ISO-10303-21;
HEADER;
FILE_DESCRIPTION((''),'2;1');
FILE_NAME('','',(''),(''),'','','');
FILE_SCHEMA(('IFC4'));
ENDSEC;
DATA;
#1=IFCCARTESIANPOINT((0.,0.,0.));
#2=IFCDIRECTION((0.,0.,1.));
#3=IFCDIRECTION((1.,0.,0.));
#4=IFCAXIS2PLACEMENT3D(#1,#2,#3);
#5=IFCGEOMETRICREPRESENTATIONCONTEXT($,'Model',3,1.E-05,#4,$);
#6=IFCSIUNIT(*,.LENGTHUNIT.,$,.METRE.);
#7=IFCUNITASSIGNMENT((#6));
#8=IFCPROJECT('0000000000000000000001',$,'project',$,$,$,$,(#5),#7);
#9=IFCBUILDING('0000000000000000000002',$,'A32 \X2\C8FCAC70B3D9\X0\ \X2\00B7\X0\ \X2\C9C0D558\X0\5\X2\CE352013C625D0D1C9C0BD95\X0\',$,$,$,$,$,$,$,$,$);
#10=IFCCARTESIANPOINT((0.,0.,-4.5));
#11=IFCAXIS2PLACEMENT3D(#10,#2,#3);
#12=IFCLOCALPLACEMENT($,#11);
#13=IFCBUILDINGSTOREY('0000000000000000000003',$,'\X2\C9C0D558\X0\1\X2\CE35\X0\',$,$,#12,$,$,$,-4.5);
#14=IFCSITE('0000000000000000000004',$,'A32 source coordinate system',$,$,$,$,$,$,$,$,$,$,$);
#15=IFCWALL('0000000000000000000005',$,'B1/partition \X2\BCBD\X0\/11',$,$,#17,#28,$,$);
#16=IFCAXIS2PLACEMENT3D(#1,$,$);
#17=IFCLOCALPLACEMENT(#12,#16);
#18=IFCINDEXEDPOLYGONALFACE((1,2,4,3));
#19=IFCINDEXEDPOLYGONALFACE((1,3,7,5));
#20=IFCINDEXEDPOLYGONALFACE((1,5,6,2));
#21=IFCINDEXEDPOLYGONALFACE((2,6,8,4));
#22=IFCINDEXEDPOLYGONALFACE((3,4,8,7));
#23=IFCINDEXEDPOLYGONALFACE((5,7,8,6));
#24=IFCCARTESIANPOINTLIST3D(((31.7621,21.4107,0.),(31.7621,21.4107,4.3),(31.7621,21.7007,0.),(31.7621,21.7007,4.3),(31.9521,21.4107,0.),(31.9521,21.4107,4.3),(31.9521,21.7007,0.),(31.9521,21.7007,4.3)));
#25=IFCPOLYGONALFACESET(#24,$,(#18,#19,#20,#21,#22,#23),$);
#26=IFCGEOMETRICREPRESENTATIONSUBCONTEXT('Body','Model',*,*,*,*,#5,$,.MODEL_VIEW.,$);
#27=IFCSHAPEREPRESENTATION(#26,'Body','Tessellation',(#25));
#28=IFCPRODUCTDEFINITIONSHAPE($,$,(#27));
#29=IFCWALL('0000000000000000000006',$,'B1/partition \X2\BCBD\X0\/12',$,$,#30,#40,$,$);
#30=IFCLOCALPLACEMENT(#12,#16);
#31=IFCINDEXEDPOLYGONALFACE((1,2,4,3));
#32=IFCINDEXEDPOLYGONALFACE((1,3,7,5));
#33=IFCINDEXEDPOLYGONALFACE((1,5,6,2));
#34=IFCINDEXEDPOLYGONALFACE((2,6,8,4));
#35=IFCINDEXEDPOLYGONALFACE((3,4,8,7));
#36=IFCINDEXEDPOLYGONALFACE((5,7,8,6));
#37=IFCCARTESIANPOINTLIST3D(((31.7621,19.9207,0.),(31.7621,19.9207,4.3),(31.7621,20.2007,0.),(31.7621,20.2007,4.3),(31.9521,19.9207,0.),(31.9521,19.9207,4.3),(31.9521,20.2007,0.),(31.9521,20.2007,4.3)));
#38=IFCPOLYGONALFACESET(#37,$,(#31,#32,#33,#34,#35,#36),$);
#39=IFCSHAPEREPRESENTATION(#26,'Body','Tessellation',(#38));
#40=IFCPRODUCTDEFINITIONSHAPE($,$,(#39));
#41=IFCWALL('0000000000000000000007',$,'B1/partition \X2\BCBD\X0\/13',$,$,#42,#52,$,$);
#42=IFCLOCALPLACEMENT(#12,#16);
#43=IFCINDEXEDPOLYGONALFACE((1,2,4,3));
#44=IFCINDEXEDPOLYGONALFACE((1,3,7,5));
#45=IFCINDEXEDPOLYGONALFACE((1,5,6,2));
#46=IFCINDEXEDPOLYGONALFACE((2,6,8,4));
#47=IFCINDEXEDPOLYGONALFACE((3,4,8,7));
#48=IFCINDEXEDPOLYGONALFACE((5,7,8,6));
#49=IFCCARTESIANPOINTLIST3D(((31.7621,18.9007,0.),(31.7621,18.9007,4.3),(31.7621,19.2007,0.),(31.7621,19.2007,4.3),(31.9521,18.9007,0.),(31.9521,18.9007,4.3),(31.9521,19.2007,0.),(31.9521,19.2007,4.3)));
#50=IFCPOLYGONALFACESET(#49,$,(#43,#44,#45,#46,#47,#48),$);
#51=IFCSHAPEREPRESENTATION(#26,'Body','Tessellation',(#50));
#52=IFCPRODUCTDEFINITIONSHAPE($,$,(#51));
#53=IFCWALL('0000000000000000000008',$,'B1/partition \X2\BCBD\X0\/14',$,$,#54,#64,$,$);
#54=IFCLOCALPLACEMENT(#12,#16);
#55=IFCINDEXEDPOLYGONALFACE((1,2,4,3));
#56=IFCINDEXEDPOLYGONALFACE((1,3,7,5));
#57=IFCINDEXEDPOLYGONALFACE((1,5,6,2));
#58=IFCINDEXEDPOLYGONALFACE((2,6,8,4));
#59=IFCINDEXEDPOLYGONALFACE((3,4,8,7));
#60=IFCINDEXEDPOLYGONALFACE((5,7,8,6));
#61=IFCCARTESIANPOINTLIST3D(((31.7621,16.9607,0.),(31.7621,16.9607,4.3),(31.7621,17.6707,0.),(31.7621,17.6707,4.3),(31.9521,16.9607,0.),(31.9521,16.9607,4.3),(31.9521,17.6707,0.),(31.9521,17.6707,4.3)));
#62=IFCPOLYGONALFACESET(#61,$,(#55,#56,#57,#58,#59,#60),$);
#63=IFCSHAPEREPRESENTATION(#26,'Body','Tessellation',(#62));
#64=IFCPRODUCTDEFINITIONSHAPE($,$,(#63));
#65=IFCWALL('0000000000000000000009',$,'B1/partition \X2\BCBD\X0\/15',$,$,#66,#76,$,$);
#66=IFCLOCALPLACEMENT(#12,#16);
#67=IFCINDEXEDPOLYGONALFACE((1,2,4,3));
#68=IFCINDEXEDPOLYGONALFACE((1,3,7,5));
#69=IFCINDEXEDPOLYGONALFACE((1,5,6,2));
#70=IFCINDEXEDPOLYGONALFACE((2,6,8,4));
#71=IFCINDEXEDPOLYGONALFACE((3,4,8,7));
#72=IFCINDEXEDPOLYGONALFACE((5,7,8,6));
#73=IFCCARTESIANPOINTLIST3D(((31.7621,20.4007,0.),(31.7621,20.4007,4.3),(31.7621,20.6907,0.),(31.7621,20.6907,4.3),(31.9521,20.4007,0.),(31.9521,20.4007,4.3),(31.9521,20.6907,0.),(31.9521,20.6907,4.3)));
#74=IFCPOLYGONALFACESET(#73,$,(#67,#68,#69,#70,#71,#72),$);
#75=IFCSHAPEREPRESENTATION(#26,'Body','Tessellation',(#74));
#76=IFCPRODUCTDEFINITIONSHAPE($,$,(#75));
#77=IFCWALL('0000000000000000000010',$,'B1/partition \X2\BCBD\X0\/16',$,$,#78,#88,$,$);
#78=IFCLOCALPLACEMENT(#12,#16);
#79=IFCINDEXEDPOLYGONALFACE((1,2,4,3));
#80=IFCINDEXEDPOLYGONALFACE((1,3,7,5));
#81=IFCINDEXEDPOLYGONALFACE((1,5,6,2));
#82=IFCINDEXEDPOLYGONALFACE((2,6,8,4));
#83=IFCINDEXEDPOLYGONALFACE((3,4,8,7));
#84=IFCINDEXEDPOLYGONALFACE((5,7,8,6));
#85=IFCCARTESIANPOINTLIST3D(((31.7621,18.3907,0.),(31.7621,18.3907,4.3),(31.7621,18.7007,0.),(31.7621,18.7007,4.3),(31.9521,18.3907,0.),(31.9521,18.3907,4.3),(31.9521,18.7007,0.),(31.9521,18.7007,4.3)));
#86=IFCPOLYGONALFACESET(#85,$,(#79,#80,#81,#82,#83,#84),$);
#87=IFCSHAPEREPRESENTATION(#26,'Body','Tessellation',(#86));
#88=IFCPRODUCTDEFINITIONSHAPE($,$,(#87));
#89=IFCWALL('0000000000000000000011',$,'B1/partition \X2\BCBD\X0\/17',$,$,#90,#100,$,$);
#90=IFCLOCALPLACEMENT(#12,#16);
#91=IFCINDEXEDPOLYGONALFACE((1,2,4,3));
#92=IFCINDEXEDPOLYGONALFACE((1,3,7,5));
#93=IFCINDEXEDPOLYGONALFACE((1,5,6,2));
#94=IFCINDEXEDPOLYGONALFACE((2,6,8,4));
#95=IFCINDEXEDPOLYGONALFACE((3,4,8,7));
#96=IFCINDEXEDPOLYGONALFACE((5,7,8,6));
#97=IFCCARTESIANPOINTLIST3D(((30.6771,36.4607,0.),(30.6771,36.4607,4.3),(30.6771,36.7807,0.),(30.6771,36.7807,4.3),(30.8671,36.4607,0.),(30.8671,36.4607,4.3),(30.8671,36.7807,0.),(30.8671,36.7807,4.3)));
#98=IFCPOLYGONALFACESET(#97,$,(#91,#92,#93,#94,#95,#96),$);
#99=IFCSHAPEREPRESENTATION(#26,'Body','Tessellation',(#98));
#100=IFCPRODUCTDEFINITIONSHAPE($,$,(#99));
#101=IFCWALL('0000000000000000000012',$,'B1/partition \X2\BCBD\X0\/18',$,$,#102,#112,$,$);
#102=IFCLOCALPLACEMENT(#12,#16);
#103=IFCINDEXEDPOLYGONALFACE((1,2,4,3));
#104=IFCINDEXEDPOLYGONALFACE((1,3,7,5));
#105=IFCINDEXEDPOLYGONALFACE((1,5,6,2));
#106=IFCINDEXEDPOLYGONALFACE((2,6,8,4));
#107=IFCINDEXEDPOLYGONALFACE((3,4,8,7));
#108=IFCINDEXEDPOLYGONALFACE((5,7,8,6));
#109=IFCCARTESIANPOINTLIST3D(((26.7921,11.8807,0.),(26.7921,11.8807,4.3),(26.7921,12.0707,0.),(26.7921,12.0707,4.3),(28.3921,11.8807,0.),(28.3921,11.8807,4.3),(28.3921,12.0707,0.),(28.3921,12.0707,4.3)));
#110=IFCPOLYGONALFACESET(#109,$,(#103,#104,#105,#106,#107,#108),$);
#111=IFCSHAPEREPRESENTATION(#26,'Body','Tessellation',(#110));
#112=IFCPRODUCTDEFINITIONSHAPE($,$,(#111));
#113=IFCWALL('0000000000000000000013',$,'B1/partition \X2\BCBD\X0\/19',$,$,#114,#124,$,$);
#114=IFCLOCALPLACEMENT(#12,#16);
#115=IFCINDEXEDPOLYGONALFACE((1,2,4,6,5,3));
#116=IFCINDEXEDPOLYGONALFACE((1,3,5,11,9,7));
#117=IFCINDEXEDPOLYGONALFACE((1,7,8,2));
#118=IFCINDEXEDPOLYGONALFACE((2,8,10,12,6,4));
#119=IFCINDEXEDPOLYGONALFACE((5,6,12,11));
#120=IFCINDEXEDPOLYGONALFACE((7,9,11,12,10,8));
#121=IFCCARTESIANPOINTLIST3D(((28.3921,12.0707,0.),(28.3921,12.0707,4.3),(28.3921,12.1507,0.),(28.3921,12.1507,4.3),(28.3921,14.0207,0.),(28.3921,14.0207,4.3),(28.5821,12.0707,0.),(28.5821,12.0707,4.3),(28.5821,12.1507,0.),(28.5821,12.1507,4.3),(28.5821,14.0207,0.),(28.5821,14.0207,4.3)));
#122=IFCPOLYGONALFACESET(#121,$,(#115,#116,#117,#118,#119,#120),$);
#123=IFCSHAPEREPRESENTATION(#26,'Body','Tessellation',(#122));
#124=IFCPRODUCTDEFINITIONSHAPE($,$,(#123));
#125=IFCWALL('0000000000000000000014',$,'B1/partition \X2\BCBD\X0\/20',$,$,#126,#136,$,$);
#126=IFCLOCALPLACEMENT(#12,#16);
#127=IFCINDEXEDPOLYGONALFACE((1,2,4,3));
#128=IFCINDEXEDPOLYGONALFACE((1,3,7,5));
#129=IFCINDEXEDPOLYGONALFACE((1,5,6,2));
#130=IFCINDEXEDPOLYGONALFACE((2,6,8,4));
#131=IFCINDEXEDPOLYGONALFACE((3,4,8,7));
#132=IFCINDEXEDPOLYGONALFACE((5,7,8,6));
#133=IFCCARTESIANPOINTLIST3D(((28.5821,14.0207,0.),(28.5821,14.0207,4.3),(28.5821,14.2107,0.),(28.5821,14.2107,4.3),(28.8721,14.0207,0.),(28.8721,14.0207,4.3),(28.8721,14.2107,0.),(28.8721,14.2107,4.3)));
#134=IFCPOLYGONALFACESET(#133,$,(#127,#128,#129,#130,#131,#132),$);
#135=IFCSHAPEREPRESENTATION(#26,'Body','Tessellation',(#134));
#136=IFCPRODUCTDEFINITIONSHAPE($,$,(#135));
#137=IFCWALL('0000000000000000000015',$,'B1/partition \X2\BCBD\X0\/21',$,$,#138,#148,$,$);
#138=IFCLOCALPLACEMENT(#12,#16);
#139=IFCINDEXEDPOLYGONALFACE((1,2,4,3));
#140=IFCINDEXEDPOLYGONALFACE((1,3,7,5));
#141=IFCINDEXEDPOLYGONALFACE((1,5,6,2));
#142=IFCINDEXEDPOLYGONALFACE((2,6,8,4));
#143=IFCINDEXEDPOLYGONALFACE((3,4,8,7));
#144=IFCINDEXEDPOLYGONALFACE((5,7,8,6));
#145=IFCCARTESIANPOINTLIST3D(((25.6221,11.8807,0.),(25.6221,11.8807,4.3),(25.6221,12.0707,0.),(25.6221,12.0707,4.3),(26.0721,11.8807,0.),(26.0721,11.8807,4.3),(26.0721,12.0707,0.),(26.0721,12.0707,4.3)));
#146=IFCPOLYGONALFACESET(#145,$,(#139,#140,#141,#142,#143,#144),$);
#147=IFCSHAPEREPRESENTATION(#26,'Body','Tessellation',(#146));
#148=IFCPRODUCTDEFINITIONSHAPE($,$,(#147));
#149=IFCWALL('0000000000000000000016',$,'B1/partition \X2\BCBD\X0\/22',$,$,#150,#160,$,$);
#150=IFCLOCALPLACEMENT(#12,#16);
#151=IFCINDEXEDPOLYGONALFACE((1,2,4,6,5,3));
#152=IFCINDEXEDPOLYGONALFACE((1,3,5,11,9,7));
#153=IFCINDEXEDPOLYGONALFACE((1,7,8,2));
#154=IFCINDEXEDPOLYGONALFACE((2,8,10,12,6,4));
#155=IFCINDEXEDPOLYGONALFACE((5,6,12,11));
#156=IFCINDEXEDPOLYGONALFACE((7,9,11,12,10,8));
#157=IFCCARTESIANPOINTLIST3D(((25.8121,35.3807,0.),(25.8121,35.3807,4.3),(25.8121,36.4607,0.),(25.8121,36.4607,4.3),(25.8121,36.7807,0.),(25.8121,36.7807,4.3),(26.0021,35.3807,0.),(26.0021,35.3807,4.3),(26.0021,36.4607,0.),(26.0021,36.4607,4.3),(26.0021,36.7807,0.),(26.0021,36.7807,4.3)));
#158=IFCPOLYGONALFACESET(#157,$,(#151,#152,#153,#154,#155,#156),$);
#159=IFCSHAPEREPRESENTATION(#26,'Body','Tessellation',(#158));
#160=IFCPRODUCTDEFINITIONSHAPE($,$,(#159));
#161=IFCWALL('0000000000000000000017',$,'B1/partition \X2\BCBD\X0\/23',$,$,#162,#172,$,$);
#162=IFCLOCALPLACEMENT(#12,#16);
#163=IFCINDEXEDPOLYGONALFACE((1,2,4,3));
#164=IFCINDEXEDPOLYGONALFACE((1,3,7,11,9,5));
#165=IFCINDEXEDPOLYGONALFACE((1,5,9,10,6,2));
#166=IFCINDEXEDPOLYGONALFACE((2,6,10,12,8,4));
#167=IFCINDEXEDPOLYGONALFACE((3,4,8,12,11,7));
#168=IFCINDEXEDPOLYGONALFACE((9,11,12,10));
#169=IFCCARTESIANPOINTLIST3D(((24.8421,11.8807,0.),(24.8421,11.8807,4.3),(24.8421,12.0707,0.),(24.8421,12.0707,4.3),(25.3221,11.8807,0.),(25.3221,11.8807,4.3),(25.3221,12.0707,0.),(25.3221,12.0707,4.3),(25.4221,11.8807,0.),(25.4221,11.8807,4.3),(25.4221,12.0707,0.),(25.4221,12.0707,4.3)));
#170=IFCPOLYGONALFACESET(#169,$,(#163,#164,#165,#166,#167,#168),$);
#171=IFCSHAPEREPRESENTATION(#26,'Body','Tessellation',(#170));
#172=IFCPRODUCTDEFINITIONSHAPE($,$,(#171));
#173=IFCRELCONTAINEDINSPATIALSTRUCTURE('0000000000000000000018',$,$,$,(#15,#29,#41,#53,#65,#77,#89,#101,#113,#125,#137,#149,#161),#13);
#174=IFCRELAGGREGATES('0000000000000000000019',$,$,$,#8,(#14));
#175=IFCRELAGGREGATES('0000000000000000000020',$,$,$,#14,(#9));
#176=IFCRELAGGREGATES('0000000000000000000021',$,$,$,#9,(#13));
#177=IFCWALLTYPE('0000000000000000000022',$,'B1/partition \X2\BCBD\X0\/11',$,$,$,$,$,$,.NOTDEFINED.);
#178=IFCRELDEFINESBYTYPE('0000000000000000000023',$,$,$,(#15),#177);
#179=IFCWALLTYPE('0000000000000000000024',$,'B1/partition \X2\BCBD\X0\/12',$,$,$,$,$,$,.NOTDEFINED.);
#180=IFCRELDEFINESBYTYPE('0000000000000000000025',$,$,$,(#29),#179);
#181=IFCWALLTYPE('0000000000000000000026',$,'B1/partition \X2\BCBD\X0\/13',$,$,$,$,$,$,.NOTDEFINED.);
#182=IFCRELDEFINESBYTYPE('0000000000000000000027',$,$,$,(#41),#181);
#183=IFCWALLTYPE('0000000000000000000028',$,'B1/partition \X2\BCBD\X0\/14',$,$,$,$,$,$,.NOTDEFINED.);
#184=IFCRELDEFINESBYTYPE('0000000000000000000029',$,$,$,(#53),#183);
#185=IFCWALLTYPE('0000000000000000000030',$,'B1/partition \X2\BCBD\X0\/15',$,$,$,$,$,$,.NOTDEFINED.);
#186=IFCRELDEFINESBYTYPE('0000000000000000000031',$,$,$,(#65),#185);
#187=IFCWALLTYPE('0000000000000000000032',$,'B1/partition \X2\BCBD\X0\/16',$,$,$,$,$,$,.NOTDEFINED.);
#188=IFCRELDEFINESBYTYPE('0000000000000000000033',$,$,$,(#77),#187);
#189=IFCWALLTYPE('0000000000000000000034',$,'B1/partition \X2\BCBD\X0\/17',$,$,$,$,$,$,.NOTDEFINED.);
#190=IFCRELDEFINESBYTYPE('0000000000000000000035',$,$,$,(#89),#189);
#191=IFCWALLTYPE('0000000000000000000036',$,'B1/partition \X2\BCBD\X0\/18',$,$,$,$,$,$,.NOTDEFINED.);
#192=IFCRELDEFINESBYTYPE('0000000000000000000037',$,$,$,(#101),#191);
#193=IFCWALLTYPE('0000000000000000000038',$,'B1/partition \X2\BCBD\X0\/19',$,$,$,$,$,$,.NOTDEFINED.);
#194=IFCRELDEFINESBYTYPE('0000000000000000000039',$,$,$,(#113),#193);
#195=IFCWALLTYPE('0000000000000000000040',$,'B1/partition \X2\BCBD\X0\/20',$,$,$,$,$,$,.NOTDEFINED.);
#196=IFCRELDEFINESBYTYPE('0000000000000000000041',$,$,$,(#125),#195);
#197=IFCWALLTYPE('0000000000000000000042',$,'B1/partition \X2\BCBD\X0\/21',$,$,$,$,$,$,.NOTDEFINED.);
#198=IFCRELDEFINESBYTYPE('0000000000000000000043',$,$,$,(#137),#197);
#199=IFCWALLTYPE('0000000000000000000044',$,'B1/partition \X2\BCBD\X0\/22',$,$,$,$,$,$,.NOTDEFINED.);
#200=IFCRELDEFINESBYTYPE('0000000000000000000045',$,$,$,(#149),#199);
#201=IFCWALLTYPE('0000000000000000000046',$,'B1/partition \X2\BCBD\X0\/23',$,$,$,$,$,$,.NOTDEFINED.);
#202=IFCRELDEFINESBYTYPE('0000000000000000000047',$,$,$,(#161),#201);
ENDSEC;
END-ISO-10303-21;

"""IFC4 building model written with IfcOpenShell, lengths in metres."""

from ifc_helpers import new_model, si_unit, frame, origin, origin_with_axes, place, context, subcontext, project, spatial, polyline, outline, extrude, source, transform, mapped, type_object, type_shapes, element, save


model = new_model("IFC4")

# Units and contexts
model_context = context("Model", 3, precision=1e-05, world=origin_with_axes())
body_context = subcontext(model_context, "Body", "Model", "MODEL_VIEW")
ifc_project = project(units=[si_unit("LENGTHUNIT", "METRE")], contexts=[model_context])

# Site, building, storey
site = spatial("IfcSite", under=ifc_project, Name="A32 source coordinate system")
building = spatial("IfcBuilding", under=site, Name="A32 주거동 · 지하5층–옥탑지붕")
storey_placement = place(None, frame((0.0, 0.0, -4.5), z_axis=(0.0, 0.0, 1.0), x_axis=(1.0, 0.0, 0.0)))
storey = spatial("IfcBuildingStorey", under=building, at=storey_placement, Name="지하1층", Elevation=-4.5)

# Walls
wall_type_1 = type_object("IfcWallType", Name="B1/partition 벽/11", PredefinedType="NOTDEFINED")
shared_shape_1 = source(origin(), body_context, "Body", "SweptSolid", [
    extrude(outline(polyline([(31.9521, 21.4107), (31.7621, 21.4107), (31.7621, 21.7007), (31.9521, 21.7007), (31.9521, 21.4107)])), origin(), (0.0, 0.0, 1.0), 4.3),
])
type_shapes(wall_type_1, [shared_shape_1])
wall_1_placement = place(storey_placement, origin_with_axes())
element("IfcWall", 1, at=wall_1_placement, inside=storey, type_object=wall_type_1, Name="B1/partition 벽/11", context=body_context, shape_type="MappedRepresentation", body=[
    mapped(shared_shape_1, transform((0.0, 0.0, 0.0), scale=1.0)),
])
wall_type_2 = type_object("IfcWallType", Name="B1/partition 벽/12", PredefinedType="NOTDEFINED")
shared_shape_2 = source(origin(), body_context, "Body", "SweptSolid", [
    extrude(outline(polyline([(31.9521, 19.9207), (31.7621, 19.9207), (31.7621, 20.2007), (31.9521, 20.2007), (31.9521, 19.9207)])), origin(), (0.0, 0.0, 1.0), 4.3),
])
type_shapes(wall_type_2, [shared_shape_2])
wall_2_placement = place(storey_placement, origin_with_axes())
element("IfcWall", 2, at=wall_2_placement, inside=storey, type_object=wall_type_2, Name="B1/partition 벽/12", context=body_context, shape_type="MappedRepresentation", body=[
    mapped(shared_shape_2, transform((0.0, 0.0, 0.0), scale=1.0)),
])
wall_type_3 = type_object("IfcWallType", Name="B1/partition 벽/13", PredefinedType="NOTDEFINED")
shared_shape_3 = source(origin(), body_context, "Body", "SweptSolid", [
    extrude(outline(polyline([(31.9521, 18.9007), (31.7621, 18.9007), (31.7621, 19.2007), (31.9521, 19.2007), (31.9521, 18.9007)])), origin(), (0.0, 0.0, 1.0), 4.3),
])
type_shapes(wall_type_3, [shared_shape_3])
wall_3_placement = place(storey_placement, origin_with_axes())
element("IfcWall", 3, at=wall_3_placement, inside=storey, type_object=wall_type_3, Name="B1/partition 벽/13", context=body_context, shape_type="MappedRepresentation", body=[
    mapped(shared_shape_3, transform((0.0, 0.0, 0.0), scale=1.0)),
])
wall_type_4 = type_object("IfcWallType", Name="B1/partition 벽/14", PredefinedType="NOTDEFINED")
shared_shape_4 = source(origin(), body_context, "Body", "SweptSolid", [
    extrude(outline(polyline([(31.9521, 16.9607), (31.7621, 16.9607), (31.7621, 17.6707), (31.9521, 17.6707), (31.9521, 16.9607)])), origin(), (0.0, 0.0, 1.0), 4.3),
])
type_shapes(wall_type_4, [shared_shape_4])
wall_4_placement = place(storey_placement, origin_with_axes())
element("IfcWall", 4, at=wall_4_placement, inside=storey, type_object=wall_type_4, Name="B1/partition 벽/14", context=body_context, shape_type="MappedRepresentation", body=[
    mapped(shared_shape_4, transform((0.0, 0.0, 0.0), scale=1.0)),
])
wall_type_5 = type_object("IfcWallType", Name="B1/partition 벽/15", PredefinedType="NOTDEFINED")
shared_shape_5 = source(origin(), body_context, "Body", "SweptSolid", [
    extrude(outline(polyline([(31.9521, 20.6907), (31.9521, 20.4007), (31.7621, 20.4007), (31.7621, 20.6907), (31.9521, 20.6907)])), origin(), (0.0, 0.0, 1.0), 4.3),
])
type_shapes(wall_type_5, [shared_shape_5])
wall_5_placement = place(storey_placement, origin_with_axes())
element("IfcWall", 5, at=wall_5_placement, inside=storey, type_object=wall_type_5, Name="B1/partition 벽/15", context=body_context, shape_type="MappedRepresentation", body=[
    mapped(shared_shape_5, transform((0.0, 0.0, 0.0), scale=1.0)),
])
wall_type_6 = type_object("IfcWallType", Name="B1/partition 벽/16", PredefinedType="NOTDEFINED")
shared_shape_6 = source(origin(), body_context, "Body", "SweptSolid", [
    extrude(outline(polyline([(31.9521, 18.7007), (31.9521, 18.3907), (31.7621, 18.3907), (31.7621, 18.7007), (31.9521, 18.7007)])), origin(), (0.0, 0.0, 1.0), 4.3),
])
type_shapes(wall_type_6, [shared_shape_6])
wall_6_placement = place(storey_placement, origin_with_axes())
element("IfcWall", 6, at=wall_6_placement, inside=storey, type_object=wall_type_6, Name="B1/partition 벽/16", context=body_context, shape_type="MappedRepresentation", body=[
    mapped(shared_shape_6, transform((0.0, 0.0, 0.0), scale=1.0)),
])
wall_type_7 = type_object("IfcWallType", Name="B1/partition 벽/17", PredefinedType="NOTDEFINED")
shared_shape_7 = source(origin(), body_context, "Body", "SweptSolid", [
    extrude(outline(polyline([(30.8671, 36.4607), (30.6771, 36.4607), (30.6771, 36.7807), (30.8671, 36.7807), (30.8671, 36.4607)])), origin(), (0.0, 0.0, 1.0), 4.3),
])
type_shapes(wall_type_7, [shared_shape_7])
wall_7_placement = place(storey_placement, origin_with_axes())
element("IfcWall", 7, at=wall_7_placement, inside=storey, type_object=wall_type_7, Name="B1/partition 벽/17", context=body_context, shape_type="MappedRepresentation", body=[
    mapped(shared_shape_7, transform((0.0, 0.0, 0.0), scale=1.0)),
])
wall_type_8 = type_object("IfcWallType", Name="B1/partition 벽/18", PredefinedType="NOTDEFINED")
shared_shape_8 = source(origin(), body_context, "Body", "SweptSolid", [
    extrude(outline(polyline([(28.3921, 12.0707), (28.3921, 11.8807), (26.7921, 11.8807), (26.7921, 12.0707), (28.3921, 12.0707)])), origin(), (0.0, 0.0, 1.0), 4.3),
])
type_shapes(wall_type_8, [shared_shape_8])
wall_8_placement = place(storey_placement, origin_with_axes())
element("IfcWall", 8, at=wall_8_placement, inside=storey, type_object=wall_type_8, Name="B1/partition 벽/18", context=body_context, shape_type="MappedRepresentation", body=[
    mapped(shared_shape_8, transform((0.0, 0.0, 0.0), scale=1.0)),
])
wall_type_9 = type_object("IfcWallType", Name="B1/partition 벽/19", PredefinedType="NOTDEFINED")
shared_shape_9 = source(origin(), body_context, "Body", "SweptSolid", [
    extrude(outline(polyline([(28.3921, 12.1507), (28.3921, 14.0207), (28.5821, 14.0207), (28.5821, 12.1507), (28.5821, 12.0707), (28.3921, 12.0707), (28.3921, 12.1507)])), origin(), (0.0, 0.0, 1.0), 4.3),
])
type_shapes(wall_type_9, [shared_shape_9])
wall_9_placement = place(storey_placement, origin_with_axes())
element("IfcWall", 9, at=wall_9_placement, inside=storey, type_object=wall_type_9, Name="B1/partition 벽/19", context=body_context, shape_type="MappedRepresentation", body=[
    mapped(shared_shape_9, transform((0.0, 0.0, 0.0), scale=1.0)),
])
wall_type_10 = type_object("IfcWallType", Name="B1/partition 벽/20", PredefinedType="NOTDEFINED")
shared_shape_10 = source(origin(), body_context, "Body", "SweptSolid", [
    extrude(outline(polyline([(28.5821, 14.2107), (28.8721, 14.2107), (28.8721, 14.0207), (28.5821, 14.0207), (28.5821, 14.2107)])), origin(), (0.0, 0.0, 1.0), 4.3),
])
type_shapes(wall_type_10, [shared_shape_10])
wall_10_placement = place(storey_placement, origin_with_axes())
element("IfcWall", 10, at=wall_10_placement, inside=storey, type_object=wall_type_10, Name="B1/partition 벽/20", context=body_context, shape_type="MappedRepresentation", body=[
    mapped(shared_shape_10, transform((0.0, 0.0, 0.0), scale=1.0)),
])
wall_type_11 = type_object("IfcWallType", Name="B1/partition 벽/21", PredefinedType="NOTDEFINED")
shared_shape_11 = source(origin(), body_context, "Body", "SweptSolid", [
    extrude(outline(polyline([(26.0721, 12.0707), (26.0721, 11.8807), (25.6221, 11.8807), (25.6221, 12.0707), (26.0721, 12.0707)])), origin(), (0.0, 0.0, 1.0), 4.3),
])
type_shapes(wall_type_11, [shared_shape_11])
wall_11_placement = place(storey_placement, origin_with_axes())
element("IfcWall", 11, at=wall_11_placement, inside=storey, type_object=wall_type_11, Name="B1/partition 벽/21", context=body_context, shape_type="MappedRepresentation", body=[
    mapped(shared_shape_11, transform((0.0, 0.0, 0.0), scale=1.0)),
])
wall_type_12 = type_object("IfcWallType", Name="B1/partition 벽/22", PredefinedType="NOTDEFINED")
shared_shape_12 = source(origin(), body_context, "Body", "SweptSolid", [
    extrude(outline(polyline([(26.0021, 35.3807), (25.8121, 35.3807), (25.8121, 36.4607), (25.8121, 36.7807), (26.0021, 36.7807), (26.0021, 36.4607), (26.0021, 35.3807)])), origin(), (0.0, 0.0, 1.0), 4.3),
])
type_shapes(wall_type_12, [shared_shape_12])
wall_12_placement = place(storey_placement, origin_with_axes())
element("IfcWall", 12, at=wall_12_placement, inside=storey, type_object=wall_type_12, Name="B1/partition 벽/22", context=body_context, shape_type="MappedRepresentation", body=[
    mapped(shared_shape_12, transform((0.0, 0.0, 0.0), scale=1.0)),
])
wall_type_13 = type_object("IfcWallType", Name="B1/partition 벽/23", PredefinedType="NOTDEFINED")
shared_shape_13 = source(origin(), body_context, "Body", "SweptSolid", [
    extrude(outline(polyline([(25.4221, 12.0707), (25.4221, 11.8807), (25.3221, 11.8807), (24.8421, 11.8807), (24.8421, 12.0707), (25.3221, 12.0707), (25.4221, 12.0707)])), origin(), (0.0, 0.0, 1.0), 4.3),
])
type_shapes(wall_type_13, [shared_shape_13])
wall_13_placement = place(storey_placement, origin_with_axes())
element("IfcWall", 13, at=wall_13_placement, inside=storey, type_object=wall_type_13, Name="B1/partition 벽/23", context=body_context, shape_type="MappedRepresentation", body=[
    mapped(shared_shape_13, transform((0.0, 0.0, 0.0), scale=1.0)),
])

save(model, "model.ifc")
